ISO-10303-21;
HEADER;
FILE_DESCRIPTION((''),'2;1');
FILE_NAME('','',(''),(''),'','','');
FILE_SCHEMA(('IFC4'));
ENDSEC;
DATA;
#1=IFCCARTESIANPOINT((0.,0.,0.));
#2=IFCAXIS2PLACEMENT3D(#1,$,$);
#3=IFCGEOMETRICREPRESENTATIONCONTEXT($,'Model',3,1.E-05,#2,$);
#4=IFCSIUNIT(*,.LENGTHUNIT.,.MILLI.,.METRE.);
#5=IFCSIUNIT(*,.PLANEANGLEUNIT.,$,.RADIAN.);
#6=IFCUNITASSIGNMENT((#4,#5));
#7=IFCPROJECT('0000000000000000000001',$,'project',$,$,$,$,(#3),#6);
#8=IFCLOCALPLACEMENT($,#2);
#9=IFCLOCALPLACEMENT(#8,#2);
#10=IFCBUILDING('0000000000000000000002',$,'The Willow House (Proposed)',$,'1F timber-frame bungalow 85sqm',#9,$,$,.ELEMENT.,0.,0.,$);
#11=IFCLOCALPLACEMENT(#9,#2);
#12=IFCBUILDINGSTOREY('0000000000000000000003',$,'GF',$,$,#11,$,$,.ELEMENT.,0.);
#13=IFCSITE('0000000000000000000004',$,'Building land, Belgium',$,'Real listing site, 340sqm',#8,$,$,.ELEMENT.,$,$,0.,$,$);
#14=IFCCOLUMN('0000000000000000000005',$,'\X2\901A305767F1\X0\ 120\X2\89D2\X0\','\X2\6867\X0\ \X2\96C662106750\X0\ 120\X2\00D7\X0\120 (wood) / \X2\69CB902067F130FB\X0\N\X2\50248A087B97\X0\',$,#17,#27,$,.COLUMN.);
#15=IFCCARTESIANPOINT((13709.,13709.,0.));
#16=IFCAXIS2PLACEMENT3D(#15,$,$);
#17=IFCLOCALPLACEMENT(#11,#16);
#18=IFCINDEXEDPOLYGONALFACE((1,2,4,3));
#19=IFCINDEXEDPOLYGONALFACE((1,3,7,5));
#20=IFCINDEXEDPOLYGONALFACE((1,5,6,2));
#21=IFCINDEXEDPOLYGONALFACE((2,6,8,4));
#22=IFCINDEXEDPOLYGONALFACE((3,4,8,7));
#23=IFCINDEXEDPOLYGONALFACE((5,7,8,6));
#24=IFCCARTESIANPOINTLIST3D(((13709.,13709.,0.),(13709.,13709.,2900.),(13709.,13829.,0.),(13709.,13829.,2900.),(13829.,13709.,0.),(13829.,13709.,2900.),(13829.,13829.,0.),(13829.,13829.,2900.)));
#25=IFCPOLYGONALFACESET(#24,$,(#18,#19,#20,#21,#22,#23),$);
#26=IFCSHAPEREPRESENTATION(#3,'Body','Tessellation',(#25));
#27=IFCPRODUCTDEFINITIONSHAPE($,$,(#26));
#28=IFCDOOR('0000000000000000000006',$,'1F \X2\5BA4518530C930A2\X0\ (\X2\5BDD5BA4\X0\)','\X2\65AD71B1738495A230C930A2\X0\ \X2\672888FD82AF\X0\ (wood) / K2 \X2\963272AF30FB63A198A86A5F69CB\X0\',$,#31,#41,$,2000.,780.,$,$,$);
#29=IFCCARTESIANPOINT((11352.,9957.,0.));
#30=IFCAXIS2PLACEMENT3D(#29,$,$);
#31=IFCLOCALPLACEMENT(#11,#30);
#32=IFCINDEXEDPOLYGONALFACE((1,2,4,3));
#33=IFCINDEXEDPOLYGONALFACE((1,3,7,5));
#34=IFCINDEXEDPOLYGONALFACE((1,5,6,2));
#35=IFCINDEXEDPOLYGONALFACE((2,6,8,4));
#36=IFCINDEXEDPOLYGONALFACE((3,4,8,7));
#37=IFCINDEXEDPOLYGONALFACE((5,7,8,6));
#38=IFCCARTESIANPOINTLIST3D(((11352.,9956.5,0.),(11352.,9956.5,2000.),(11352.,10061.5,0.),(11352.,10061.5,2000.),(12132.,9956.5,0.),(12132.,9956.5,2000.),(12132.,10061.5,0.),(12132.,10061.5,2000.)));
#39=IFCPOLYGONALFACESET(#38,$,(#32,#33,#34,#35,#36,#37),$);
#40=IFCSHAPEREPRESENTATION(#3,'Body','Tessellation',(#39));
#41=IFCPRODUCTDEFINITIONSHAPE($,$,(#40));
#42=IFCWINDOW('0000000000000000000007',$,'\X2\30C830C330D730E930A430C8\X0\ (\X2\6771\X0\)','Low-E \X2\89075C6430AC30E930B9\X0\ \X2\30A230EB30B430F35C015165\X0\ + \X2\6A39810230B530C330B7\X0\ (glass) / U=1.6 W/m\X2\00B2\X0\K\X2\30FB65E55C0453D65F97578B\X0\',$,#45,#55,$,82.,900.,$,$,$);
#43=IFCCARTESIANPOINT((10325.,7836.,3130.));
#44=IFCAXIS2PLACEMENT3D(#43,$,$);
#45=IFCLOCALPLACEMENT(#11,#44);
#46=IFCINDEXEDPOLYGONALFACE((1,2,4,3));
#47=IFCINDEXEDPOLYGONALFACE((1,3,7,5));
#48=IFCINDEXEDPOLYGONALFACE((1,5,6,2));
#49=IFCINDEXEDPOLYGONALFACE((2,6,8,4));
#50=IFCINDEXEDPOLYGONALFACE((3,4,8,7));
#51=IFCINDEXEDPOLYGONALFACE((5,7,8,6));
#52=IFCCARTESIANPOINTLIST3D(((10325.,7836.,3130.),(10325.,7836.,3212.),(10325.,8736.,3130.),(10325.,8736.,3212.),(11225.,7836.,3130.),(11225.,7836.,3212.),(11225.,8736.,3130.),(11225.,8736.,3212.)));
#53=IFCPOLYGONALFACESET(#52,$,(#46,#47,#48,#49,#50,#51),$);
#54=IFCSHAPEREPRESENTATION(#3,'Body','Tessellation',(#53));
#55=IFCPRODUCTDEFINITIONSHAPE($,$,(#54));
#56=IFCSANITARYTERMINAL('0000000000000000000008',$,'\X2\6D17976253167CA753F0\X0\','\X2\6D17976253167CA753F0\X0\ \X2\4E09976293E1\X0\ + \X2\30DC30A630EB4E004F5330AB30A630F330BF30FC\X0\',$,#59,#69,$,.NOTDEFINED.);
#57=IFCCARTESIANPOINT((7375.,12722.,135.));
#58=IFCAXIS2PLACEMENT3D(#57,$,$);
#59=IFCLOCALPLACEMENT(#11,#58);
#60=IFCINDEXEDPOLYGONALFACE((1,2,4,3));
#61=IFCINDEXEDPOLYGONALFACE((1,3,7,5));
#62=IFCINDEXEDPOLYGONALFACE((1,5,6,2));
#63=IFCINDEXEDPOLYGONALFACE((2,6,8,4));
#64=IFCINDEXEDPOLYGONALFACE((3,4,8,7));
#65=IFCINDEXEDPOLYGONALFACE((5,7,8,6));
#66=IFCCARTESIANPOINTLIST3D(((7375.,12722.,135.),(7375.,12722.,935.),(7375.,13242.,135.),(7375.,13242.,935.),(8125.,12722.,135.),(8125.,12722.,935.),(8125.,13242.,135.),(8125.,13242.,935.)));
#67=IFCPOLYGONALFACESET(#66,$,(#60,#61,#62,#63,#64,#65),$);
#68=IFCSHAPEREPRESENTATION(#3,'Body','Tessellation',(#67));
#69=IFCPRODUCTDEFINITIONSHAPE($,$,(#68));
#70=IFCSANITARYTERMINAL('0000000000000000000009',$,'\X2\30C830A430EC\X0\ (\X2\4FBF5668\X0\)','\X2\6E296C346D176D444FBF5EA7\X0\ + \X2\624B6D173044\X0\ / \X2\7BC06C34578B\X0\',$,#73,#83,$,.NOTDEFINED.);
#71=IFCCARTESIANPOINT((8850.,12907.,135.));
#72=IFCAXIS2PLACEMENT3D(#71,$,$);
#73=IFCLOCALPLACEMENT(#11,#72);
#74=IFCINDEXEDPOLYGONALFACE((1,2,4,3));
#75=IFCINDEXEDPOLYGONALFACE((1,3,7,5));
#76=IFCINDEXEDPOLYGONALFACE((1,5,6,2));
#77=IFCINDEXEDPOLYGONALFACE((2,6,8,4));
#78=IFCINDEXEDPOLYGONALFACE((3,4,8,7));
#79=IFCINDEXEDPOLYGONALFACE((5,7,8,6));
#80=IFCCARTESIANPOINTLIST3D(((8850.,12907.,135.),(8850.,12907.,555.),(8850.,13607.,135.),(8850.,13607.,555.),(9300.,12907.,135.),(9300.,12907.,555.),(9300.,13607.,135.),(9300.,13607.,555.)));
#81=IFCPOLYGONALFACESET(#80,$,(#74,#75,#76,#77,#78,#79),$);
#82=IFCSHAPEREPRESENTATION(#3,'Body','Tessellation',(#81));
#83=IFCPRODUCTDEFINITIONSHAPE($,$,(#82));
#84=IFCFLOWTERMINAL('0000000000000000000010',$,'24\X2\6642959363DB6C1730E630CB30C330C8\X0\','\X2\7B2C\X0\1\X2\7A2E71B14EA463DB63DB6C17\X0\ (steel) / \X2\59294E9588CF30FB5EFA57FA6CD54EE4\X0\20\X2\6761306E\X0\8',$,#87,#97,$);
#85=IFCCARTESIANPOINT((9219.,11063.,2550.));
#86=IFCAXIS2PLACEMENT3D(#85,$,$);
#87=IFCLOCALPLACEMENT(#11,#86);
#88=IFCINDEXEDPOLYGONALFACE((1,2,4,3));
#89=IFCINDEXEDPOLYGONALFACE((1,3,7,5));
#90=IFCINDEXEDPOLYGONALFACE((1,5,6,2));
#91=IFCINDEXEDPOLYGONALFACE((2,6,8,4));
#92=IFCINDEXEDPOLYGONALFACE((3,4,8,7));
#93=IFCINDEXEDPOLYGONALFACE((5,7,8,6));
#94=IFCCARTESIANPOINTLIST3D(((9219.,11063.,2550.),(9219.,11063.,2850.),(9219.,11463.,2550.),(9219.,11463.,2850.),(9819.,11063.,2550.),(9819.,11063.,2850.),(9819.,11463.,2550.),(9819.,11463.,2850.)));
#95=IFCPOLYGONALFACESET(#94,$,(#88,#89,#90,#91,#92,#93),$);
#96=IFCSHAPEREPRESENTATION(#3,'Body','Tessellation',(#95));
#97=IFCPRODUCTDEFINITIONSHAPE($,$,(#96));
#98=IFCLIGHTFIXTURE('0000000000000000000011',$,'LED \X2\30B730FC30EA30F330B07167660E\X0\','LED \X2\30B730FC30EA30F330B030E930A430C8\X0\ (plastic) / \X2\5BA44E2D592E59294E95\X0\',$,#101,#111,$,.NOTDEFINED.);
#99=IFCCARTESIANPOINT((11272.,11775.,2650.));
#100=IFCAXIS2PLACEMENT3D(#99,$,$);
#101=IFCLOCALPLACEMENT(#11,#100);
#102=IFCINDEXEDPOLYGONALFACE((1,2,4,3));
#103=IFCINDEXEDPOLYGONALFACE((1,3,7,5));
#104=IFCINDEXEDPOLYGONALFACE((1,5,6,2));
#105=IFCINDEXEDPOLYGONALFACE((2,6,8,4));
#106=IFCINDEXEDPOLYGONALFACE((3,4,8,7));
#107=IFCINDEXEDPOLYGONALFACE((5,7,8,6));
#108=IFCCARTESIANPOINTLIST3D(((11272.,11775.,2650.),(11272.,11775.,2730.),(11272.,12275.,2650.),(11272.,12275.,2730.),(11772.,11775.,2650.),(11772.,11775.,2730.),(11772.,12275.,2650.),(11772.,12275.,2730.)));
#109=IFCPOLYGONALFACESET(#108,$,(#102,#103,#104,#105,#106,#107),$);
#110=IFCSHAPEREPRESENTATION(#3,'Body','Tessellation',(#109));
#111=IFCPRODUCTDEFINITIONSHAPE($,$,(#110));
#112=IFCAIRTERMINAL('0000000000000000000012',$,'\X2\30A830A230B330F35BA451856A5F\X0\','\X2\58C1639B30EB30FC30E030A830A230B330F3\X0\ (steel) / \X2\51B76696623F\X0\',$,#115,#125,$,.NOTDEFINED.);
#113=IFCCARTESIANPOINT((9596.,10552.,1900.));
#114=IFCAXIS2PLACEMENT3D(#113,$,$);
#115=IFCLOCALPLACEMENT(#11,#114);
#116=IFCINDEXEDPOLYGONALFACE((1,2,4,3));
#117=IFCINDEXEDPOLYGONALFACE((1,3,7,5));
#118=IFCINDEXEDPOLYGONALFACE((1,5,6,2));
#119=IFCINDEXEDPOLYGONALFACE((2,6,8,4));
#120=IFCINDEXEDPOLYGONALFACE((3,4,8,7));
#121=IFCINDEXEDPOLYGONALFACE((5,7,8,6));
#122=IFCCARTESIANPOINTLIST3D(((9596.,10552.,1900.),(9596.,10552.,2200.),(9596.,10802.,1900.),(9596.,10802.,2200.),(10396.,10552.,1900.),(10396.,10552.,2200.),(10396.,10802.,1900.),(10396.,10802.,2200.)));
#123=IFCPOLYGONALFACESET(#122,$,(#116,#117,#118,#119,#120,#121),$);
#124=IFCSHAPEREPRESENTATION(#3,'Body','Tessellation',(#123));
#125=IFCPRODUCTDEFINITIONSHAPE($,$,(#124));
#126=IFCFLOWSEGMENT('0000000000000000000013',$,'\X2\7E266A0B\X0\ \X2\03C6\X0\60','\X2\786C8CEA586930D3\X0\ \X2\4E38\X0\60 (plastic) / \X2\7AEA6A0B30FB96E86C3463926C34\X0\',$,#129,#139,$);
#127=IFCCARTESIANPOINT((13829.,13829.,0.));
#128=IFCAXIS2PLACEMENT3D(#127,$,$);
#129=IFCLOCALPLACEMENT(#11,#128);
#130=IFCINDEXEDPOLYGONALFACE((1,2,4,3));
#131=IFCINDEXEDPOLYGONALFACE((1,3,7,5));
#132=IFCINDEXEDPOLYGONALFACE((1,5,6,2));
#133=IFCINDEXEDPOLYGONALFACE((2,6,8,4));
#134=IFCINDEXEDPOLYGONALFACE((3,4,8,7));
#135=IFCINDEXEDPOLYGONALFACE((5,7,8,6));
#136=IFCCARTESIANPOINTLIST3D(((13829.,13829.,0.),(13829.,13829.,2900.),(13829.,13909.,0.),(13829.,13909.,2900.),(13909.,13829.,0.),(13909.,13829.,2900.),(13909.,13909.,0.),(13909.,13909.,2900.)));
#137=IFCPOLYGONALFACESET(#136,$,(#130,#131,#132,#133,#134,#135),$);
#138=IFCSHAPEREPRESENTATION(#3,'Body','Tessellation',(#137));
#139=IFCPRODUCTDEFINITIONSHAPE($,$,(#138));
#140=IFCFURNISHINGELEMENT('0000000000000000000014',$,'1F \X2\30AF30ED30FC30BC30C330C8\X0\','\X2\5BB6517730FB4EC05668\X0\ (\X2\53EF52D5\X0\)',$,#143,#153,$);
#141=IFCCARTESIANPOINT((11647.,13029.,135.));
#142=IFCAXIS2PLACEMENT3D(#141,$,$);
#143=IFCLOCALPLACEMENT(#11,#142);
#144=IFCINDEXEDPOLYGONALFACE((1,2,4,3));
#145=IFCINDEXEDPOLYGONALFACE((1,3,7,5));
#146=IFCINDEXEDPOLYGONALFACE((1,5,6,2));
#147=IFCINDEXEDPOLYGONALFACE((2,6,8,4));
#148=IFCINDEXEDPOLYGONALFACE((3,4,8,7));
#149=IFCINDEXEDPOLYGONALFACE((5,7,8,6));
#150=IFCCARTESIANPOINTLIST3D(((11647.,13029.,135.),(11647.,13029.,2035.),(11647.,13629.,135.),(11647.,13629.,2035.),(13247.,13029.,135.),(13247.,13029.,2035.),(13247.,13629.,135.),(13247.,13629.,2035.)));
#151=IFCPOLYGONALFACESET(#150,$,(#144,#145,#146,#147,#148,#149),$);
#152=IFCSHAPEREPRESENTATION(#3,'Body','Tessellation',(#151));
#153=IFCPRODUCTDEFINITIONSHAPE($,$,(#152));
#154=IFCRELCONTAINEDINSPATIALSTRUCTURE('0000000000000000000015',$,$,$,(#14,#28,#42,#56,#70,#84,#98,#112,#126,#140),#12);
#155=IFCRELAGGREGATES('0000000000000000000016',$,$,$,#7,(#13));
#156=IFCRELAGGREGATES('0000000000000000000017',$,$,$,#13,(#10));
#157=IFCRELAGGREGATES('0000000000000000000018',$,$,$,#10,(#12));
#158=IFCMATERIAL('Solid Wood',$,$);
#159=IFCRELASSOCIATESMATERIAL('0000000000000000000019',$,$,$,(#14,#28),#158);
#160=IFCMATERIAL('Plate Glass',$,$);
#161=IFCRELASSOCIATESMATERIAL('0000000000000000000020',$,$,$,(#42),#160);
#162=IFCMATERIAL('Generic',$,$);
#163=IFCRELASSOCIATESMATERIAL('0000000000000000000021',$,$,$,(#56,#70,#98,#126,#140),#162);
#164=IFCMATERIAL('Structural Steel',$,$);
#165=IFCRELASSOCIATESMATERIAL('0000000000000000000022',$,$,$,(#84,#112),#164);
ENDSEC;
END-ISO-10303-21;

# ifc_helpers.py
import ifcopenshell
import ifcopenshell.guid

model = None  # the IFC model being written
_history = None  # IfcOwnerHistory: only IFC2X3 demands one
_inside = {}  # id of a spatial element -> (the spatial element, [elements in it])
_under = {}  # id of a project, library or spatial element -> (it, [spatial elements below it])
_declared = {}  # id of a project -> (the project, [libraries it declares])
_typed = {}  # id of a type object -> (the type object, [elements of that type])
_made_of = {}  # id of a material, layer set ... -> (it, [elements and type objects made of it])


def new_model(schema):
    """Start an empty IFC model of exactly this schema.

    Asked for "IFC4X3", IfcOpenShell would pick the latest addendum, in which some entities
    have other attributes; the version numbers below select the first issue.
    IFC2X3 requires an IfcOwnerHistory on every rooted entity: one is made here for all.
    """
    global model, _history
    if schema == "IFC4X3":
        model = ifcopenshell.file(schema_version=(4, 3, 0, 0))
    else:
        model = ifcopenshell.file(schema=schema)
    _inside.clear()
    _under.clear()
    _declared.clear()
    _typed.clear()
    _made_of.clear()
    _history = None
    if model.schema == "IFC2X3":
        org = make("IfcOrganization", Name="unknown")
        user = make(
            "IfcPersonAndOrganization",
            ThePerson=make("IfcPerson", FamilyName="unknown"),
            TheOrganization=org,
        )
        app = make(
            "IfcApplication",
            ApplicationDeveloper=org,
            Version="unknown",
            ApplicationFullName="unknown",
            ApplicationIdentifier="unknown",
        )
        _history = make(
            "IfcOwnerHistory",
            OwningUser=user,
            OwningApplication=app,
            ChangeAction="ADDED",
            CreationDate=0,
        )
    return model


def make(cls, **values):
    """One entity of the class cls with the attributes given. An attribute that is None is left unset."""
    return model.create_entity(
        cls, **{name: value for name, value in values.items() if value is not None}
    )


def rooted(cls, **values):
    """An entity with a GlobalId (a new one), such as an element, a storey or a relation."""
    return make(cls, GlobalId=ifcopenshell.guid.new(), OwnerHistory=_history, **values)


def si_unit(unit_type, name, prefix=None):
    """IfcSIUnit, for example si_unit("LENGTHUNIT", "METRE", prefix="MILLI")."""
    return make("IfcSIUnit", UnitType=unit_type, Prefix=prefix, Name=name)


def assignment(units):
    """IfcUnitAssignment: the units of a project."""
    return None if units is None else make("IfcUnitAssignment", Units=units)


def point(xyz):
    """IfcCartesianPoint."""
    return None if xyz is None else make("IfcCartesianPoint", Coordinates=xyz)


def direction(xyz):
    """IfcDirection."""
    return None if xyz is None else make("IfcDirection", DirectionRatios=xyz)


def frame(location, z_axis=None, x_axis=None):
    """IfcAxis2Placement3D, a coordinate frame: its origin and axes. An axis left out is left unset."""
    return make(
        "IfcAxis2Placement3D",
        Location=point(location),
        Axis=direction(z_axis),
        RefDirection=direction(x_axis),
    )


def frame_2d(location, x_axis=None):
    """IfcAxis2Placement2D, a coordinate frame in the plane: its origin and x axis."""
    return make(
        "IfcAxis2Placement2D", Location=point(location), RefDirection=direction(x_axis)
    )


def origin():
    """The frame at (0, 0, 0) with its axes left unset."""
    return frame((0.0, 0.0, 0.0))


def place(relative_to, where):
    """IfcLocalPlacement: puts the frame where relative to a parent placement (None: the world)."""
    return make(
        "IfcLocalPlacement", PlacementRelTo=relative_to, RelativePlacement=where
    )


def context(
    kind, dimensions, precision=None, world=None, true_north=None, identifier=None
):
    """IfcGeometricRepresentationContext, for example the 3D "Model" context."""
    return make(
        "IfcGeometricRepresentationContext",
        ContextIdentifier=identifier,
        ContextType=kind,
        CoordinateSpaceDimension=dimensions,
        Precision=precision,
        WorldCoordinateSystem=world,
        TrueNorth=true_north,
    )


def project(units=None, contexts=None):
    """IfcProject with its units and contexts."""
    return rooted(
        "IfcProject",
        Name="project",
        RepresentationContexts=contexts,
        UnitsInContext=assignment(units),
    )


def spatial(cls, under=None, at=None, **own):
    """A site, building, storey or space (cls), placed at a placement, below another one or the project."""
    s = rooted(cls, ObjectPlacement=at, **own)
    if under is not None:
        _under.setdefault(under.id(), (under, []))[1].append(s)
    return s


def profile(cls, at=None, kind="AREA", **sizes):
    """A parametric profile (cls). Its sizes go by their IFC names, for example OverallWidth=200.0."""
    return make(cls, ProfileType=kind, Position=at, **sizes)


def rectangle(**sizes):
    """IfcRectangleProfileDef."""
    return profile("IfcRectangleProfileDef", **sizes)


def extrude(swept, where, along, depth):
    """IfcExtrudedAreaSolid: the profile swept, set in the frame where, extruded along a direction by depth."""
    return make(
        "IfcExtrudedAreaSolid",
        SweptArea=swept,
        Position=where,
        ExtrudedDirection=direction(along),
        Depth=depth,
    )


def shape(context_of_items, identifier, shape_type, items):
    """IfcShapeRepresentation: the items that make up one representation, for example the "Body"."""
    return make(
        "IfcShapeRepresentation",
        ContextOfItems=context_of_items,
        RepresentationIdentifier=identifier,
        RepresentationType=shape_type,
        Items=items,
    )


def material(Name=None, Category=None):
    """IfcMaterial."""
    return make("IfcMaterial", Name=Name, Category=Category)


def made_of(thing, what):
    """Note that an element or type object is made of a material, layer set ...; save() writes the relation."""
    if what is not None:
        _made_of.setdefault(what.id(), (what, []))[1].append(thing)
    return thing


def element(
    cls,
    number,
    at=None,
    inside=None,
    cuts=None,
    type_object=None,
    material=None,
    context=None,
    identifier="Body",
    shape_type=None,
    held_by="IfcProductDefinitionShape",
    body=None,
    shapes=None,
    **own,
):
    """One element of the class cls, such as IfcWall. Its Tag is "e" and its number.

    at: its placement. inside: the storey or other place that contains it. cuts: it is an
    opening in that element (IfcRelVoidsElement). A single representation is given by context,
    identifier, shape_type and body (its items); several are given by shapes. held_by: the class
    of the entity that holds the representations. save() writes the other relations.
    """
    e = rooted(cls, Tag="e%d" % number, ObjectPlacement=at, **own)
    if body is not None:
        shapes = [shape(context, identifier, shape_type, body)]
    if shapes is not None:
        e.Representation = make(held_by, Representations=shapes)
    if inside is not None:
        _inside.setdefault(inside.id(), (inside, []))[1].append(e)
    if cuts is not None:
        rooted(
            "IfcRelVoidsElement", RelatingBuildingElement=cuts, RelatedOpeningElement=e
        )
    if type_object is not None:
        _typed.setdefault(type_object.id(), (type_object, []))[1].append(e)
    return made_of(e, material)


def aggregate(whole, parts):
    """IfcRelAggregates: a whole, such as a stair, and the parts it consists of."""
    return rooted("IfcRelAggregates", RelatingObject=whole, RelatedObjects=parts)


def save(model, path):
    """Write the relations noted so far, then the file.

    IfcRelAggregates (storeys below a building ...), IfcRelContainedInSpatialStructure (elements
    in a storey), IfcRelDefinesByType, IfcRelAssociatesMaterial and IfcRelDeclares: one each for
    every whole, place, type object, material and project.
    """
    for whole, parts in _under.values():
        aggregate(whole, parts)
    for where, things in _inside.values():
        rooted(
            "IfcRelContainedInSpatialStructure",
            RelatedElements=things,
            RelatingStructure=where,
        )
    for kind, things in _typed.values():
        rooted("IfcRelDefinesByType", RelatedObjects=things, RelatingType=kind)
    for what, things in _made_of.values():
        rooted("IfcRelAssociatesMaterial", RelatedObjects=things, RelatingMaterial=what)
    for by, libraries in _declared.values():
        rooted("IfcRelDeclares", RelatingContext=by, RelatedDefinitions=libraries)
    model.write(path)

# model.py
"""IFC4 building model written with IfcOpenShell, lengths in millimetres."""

from ifc_helpers import new_model, si_unit, frame, frame_2d, origin, place, context, project, spatial, rectangle, extrude, material, element, save


model = new_model("IFC4")

# Units and contexts
model_context = context("Model", 3, precision=1e-05, world=origin())
ifc_project = project(units=[si_unit("LENGTHUNIT", "METRE", prefix="MILLI"), si_unit("PLANEANGLEUNIT", "RADIAN")], contexts=[model_context])

# Site, building, storey
site_placement = place(None, origin())
site = spatial("IfcSite", under=ifc_project, at=site_placement, Name="Building land, Belgium", ObjectType="Real listing site, 340sqm", CompositionType="ELEMENT", RefElevation=0.0)
building_placement = place(site_placement, origin())
building = spatial("IfcBuilding", under=site, at=building_placement, Name="The Willow House (Proposed)", ObjectType="1F timber-frame bungalow 85sqm", CompositionType="ELEMENT", ElevationOfRefHeight=0.0, ElevationOfTerrain=0.0)
storey_placement = place(building_placement, origin())
storey = spatial("IfcBuildingStorey", under=building, at=storey_placement, Name="GF", CompositionType="ELEMENT", Elevation=0.0)

# Column
ifc_material_1 = material(Name="Solid Wood")
column_1_placement = place(storey_placement, frame((13709.0, 13709.0, 0.0)))
element("IfcColumn", 1, at=column_1_placement, inside=storey, material=ifc_material_1, Name="通し柱 120角", Description="桧 集成材 120×120 (wood) / 構造柱・N値計算", PredefinedType="COLUMN", context=model_context, shape_type="SweptSolid", body=[
    extrude(rectangle(XDim=120.0, YDim=120.0, at=frame_2d((60.0, 60.0))), frame((13709.0, 13709.0, 0.0)), (0.0, 0.0, 1.0), 2900.0),
])

# Door
door_placement = place(storey_placement, frame((11352.0, 9957.0, 0.0)))
element("IfcDoor", 2, at=door_placement, inside=storey, material=ifc_material_1, Name="1F 室内ドア (寝室)", Description="断熱玄関ドア 木製芯 (wood) / K2 防犯・採風機構", OverallHeight=2000.0, OverallWidth=780.0, context=model_context, shape_type="SweptSolid", body=[
    extrude(rectangle(XDim=780.0, YDim=105.0, at=frame_2d((390.0, 52.0))), frame((11352.0, 9957.0, 0.0)), (0.0, 0.0, 1.0), 2000.0),
])

# Window
ifc_material_2 = material(Name="Plate Glass")
window_placement = place(storey_placement, frame((10325.0, 7836.0, 3130.0)))
element("IfcWindow", 3, at=window_placement, inside=storey, material=ifc_material_2, Name="トップライト (東)", Description="Low-E 複層ガラス アルゴン封入 + 樹脂サッシ (glass) / U=1.6 W/m²K・日射取得型", OverallHeight=82.0, OverallWidth=900.0, context=model_context, shape_type="SweptSolid", body=[
    extrude(rectangle(XDim=900.0, YDim=900.0, at=frame_2d((450.0, 450.0))), frame((10325.0, 7836.0, 3130.0)), (0.0, 0.0, 1.0), 82.0),
])

# Sanitary terminals
ifc_material_3 = material(Name="Generic")
sanitary_terminal_1_placement = place(storey_placement, frame((7375.0, 12722.0, 135.0)))
element("IfcSanitaryTerminal", 4, at=sanitary_terminal_1_placement, inside=storey, material=ifc_material_3, Name="洗面化粧台", Description="洗面化粧台 三面鏡 + ボウル一体カウンター", PredefinedType="NOTDEFINED", context=model_context, shape_type="SweptSolid", body=[
    extrude(rectangle(XDim=750.0, YDim=520.0, at=frame_2d((375.0, 260.0))), frame((7375.0, 12722.0, 135.0)), (0.0, 0.0, 1.0), 800.0),
])
sanitary_terminal_2_placement = place(storey_placement, frame((8850.0, 12907.0, 135.0)))
element("IfcSanitaryTerminal", 5, at=sanitary_terminal_2_placement, inside=storey, material=ifc_material_3, Name="トイレ (便器)", Description="温水洗浄便座 + 手洗い / 節水型", PredefinedType="NOTDEFINED", context=model_context, shape_type="SweptSolid", body=[
    extrude(rectangle(XDim=450.0, YDim=700.0, at=frame_2d((225.0, 350.0))), frame((8850.0, 12907.0, 135.0)), (0.0, 0.0, 1.0), 420.0),
])

# Flow terminal
ifc_material_4 = material(Name="Structural Steel")
flow_terminal_placement = place(storey_placement, frame((9219.0, 11063.0, 2550.0)))
element("IfcFlowTerminal", 6, at=flow_terminal_placement, inside=storey, material=ifc_material_4, Name="24時間換気ユニット", Description="第1種熱交換換気 (steel) / 天井裏・建基法令20条の8", context=model_context, shape_type="SweptSolid", body=[
    extrude(rectangle(XDim=600.0, YDim=400.0, at=frame_2d((300.0, 200.0))), frame((9219.0, 11063.0, 2550.0)), (0.0, 0.0, 1.0), 300.0),
])

# Light fixture
light_fixture_placement = place(storey_placement, frame((11272.0, 11775.0, 2650.0)))
element("IfcLightFixture", 7, at=light_fixture_placement, inside=storey, material=ifc_material_3, Name="LED シーリング照明", Description="LED シーリングライト (plastic) / 室中央天井", PredefinedType="NOTDEFINED", context=model_context, shape_type="SweptSolid", body=[
    extrude(rectangle(XDim=500.0, YDim=500.0, at=frame_2d((250.0, 250.0))), frame((11272.0, 11775.0, 2650.0)), (0.0, 0.0, 1.0), 80.0),
])

# Air terminal
air_terminal_placement = place(storey_placement, frame((9596.0, 10552.0, 1900.0)))
element("IfcAirTerminal", 8, at=air_terminal_placement, inside=storey, material=ifc_material_4, Name="エアコン室内機", Description="壁掛ルームエアコン (steel) / 冷暖房", PredefinedType="NOTDEFINED", context=model_context, shape_type="SweptSolid", body=[
    extrude(rectangle(XDim=800.0, YDim=250.0, at=frame_2d((400.0, 125.0))), frame((9596.0, 10552.0, 1900.0)), (0.0, 0.0, 1.0), 300.0),
])

# Flow segment
flow_segment_placement = place(storey_placement, frame((13829.0, 13829.0, 0.0)))
element("IfcFlowSegment", 9, at=flow_segment_placement, inside=storey, material=ifc_material_3, Name="縦樋 φ60", Description="硬質塩ビ 丸60 (plastic) / 竪樋・雨水排水", context=model_context, shape_type="SweptSolid", body=[
    extrude(rectangle(XDim=80.0, YDim=80.0, at=frame_2d((40.0, 40.0))), frame((13829.0, 13829.0, 0.0)), (0.0, 0.0, 1.0), 2900.0),
])

# Furnishing element
furnishing_placement = place(storey_placement, frame((11647.0, 13029.0, 135.0)))
element("IfcFurnishingElement", 10, at=furnishing_placement, inside=storey, material=ifc_material_3, Name="1F クローゼット", Description="家具・什器 (可動)", context=model_context, shape_type="SweptSolid", body=[
    extrude(rectangle(XDim=1600.0, YDim=600.0, at=frame_2d((800.0, 300.0))), frame((11647.0, 13029.0, 135.0)), (0.0, 0.0, 1.0), 1900.0),
])

save(model, "model.ifc")
